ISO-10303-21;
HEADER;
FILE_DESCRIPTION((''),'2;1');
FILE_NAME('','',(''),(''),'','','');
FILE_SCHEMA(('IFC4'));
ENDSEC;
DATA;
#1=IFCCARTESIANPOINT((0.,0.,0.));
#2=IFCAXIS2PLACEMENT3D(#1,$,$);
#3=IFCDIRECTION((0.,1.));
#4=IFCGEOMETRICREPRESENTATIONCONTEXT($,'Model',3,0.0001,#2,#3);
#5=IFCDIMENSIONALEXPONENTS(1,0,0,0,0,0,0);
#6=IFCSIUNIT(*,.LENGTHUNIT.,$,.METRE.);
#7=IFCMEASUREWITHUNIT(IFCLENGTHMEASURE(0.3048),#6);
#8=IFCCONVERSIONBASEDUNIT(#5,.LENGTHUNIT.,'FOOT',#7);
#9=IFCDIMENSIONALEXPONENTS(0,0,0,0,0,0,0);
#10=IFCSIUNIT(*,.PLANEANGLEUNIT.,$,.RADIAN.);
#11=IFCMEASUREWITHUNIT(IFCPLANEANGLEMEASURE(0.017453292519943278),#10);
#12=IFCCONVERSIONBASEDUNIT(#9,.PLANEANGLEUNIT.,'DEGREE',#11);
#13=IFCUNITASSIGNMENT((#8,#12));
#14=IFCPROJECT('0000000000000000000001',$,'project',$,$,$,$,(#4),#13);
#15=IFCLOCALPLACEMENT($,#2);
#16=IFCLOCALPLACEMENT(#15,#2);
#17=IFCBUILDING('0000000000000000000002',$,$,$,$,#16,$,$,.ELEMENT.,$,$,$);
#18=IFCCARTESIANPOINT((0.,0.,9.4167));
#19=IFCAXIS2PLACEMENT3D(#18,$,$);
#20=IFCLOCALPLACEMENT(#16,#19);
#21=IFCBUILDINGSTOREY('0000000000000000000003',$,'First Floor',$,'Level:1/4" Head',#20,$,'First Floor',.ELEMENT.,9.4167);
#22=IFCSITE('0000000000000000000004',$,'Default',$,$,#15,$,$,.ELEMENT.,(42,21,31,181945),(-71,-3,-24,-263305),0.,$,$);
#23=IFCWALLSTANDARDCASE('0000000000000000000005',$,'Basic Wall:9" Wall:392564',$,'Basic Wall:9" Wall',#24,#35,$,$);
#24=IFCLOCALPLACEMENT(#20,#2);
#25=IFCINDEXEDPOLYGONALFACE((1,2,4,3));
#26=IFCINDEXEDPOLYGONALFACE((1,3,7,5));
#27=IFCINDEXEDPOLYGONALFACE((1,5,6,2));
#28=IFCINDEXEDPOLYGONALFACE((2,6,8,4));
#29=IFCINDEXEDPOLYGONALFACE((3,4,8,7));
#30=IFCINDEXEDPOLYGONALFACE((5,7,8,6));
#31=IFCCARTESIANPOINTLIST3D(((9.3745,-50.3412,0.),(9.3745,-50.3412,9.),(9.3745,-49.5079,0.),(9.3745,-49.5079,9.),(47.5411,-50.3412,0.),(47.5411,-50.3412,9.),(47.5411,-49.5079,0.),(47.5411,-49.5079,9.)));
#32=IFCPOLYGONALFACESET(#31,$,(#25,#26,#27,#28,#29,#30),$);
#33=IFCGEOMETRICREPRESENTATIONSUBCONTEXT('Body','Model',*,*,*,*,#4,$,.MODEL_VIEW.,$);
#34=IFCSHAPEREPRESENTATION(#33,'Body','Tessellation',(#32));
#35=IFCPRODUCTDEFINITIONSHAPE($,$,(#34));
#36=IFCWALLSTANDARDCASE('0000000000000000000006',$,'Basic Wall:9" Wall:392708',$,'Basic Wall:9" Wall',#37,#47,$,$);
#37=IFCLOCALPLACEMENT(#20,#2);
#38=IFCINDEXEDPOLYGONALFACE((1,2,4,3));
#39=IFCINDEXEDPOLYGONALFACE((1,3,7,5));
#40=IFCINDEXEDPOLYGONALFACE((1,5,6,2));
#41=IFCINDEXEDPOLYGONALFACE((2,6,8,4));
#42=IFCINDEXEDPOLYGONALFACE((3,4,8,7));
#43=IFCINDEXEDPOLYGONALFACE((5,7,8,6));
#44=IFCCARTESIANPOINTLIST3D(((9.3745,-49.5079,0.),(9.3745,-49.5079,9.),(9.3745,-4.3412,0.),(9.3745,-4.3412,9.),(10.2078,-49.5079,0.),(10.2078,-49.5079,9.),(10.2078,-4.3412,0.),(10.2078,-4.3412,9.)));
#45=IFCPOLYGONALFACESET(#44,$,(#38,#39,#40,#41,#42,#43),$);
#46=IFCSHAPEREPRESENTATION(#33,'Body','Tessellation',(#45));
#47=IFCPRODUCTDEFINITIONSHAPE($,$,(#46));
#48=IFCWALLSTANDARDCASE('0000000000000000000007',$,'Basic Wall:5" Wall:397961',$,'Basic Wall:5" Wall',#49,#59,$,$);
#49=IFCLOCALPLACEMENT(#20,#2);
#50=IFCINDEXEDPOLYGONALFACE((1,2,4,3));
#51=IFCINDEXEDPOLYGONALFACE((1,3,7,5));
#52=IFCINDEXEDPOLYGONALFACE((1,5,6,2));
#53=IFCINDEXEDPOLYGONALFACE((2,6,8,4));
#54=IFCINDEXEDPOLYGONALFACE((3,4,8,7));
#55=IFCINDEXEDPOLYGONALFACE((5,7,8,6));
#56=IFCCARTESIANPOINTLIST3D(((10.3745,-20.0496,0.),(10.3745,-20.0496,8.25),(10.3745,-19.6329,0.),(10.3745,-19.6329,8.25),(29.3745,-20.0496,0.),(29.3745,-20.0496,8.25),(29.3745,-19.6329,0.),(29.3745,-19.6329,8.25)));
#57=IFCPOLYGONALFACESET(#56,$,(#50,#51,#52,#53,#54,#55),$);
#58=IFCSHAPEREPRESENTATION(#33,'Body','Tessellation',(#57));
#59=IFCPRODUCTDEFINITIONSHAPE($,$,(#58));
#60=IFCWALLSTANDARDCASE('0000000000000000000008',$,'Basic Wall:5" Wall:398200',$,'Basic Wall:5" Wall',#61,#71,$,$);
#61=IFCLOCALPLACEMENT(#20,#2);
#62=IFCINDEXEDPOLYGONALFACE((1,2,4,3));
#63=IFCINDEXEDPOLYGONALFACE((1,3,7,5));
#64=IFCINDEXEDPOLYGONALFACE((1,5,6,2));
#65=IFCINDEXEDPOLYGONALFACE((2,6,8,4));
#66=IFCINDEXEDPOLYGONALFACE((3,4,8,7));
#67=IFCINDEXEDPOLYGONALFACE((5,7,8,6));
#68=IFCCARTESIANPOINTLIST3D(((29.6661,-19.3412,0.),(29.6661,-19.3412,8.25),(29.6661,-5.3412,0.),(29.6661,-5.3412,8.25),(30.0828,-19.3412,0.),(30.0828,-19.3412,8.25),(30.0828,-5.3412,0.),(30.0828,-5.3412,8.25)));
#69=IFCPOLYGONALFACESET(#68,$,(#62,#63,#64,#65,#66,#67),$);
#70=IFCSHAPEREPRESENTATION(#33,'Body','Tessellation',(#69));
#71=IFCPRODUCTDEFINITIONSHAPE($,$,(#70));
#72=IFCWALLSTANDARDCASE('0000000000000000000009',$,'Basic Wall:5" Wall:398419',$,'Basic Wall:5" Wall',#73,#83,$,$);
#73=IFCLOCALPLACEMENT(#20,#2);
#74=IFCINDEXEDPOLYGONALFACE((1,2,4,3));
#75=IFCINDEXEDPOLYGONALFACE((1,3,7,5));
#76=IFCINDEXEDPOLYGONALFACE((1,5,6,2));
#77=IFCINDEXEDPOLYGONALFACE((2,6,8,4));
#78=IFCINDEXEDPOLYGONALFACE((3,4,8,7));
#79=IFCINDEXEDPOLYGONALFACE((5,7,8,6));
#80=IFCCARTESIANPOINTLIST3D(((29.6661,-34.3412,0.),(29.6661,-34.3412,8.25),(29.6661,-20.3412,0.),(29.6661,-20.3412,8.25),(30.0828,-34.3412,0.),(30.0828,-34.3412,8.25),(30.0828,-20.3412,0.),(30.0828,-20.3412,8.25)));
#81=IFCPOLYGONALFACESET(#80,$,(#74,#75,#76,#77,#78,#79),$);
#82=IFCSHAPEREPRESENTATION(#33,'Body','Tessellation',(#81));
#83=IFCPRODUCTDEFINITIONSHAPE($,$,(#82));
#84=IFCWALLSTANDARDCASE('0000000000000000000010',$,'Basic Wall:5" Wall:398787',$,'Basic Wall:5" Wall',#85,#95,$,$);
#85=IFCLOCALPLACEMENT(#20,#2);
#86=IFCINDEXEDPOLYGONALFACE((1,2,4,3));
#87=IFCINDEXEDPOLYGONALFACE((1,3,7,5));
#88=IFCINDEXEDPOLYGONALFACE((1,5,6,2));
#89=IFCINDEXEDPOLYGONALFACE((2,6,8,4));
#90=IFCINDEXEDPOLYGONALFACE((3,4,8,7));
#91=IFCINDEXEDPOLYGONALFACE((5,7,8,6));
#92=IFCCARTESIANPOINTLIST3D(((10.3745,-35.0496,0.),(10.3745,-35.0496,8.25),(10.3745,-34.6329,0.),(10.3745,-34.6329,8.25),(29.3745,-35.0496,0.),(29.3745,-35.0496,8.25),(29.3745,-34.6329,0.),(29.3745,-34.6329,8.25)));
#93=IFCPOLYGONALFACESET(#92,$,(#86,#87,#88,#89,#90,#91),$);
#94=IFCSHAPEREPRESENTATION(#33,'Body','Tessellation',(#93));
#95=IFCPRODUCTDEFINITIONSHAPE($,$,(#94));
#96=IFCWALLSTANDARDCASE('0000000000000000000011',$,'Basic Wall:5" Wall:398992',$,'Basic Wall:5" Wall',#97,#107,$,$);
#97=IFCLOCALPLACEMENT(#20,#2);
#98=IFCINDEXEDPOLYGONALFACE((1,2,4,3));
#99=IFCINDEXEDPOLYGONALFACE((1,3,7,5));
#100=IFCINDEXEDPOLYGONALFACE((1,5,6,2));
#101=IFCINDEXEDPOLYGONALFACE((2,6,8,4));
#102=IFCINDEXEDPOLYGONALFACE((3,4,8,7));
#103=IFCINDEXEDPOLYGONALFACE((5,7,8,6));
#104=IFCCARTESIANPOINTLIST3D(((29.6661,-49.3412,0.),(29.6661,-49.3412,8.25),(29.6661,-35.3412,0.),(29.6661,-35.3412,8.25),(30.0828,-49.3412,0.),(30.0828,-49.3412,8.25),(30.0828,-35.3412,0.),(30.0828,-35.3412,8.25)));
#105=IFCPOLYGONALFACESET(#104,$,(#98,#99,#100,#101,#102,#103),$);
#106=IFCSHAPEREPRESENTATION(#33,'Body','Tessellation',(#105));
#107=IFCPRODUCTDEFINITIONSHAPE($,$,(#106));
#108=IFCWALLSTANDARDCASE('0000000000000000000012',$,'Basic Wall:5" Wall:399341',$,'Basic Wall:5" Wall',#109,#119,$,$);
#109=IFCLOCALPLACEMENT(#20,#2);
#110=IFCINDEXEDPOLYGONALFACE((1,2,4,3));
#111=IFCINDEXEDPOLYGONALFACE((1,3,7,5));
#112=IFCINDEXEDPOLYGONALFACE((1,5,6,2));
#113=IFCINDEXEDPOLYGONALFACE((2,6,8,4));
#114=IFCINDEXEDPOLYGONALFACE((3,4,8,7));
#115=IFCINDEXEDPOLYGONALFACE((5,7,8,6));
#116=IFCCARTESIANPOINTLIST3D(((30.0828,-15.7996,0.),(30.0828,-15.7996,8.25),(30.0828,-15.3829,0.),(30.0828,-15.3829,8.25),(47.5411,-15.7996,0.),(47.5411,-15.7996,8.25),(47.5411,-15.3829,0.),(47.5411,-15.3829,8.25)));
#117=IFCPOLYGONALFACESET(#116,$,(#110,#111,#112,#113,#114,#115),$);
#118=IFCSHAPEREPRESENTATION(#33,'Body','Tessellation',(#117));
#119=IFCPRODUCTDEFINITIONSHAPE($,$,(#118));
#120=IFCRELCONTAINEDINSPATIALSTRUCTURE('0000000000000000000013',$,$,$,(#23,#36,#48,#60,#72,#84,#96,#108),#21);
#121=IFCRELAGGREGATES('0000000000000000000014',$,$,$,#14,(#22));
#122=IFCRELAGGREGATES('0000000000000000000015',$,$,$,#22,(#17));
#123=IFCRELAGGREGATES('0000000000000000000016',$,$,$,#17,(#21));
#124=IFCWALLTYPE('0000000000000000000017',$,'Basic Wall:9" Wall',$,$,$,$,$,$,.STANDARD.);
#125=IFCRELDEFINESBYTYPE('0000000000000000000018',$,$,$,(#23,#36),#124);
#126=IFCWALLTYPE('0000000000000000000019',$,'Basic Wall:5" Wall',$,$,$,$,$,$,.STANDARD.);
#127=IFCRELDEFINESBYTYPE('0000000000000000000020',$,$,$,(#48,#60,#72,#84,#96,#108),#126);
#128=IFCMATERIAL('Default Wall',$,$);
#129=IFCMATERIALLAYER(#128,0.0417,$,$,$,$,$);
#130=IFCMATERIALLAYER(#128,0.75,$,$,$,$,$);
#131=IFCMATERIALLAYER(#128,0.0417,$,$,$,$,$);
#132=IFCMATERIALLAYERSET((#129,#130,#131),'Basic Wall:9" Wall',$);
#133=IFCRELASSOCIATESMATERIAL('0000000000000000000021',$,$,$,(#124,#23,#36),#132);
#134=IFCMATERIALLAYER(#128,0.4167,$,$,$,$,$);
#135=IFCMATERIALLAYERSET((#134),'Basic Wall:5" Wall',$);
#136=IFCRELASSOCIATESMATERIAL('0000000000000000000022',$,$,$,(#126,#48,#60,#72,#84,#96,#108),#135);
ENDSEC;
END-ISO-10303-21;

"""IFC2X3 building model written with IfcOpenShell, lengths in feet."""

from ifc_helpers import new_model, entity, si_unit, converted_unit, direction, frame, frame_2d, origin, place, context, subcontext, project, spatial, rectangle, extrude, material, layer, layer_set, layer_usage, type_object, element, save


model = new_model("IFC2X3")

# Units and contexts
model_context = context("Model", 3, precision=0.0001, world=origin(), true_north=direction((0.0, 1.0)))
body_context = subcontext(model_context, "Body", "Model", "MODEL_VIEW")
ifc_project = project(units=[converted_unit("LENGTHUNIT", "FOOT", entity("IfcLengthMeasure", 0.3048), si_unit("LENGTHUNIT", "METRE"), dimensions=[1, 0, 0, 0, 0, 0, 0]), converted_unit("PLANEANGLEUNIT", "DEGREE", entity("IfcPlaneAngleMeasure", 0.017453292519943278), si_unit("PLANEANGLEUNIT", "RADIAN"), dimensions=[0, 0, 0, 0, 0, 0, 0])], contexts=[model_context])

# Site, building, storey
site_placement = place(None, origin())
site = spatial("IfcSite", under=ifc_project, at=site_placement, Name="Default", CompositionType="ELEMENT", RefLatitude=(42, 21, 31, 181945), RefLongitude=(-71, -3, -24, -263305), RefElevation=0.0)
building_placement = place(site_placement, origin())
building = spatial("IfcBuilding", under=site, at=building_placement, CompositionType="ELEMENT")
storey_placement = place(building_placement, frame((0.0, 0.0, 9.4167)))
storey = spatial("IfcBuildingStorey", under=building, at=storey_placement, Name="First Floor", ObjectType="Level:1/4\" Head", LongName="First Floor", CompositionType="ELEMENT", Elevation=9.4167)

# Walls
ifc_material_1 = material(Name="Default Wall")
ifc_layer_1 = layer(ifc_material_1, 0.0417)
ifc_layer_2 = layer(ifc_material_1, 0.75)
ifc_layer_3 = layer(ifc_material_1, 0.0417)
ifc_layer_set_1 = layer_set([ifc_layer_1, ifc_layer_2, ifc_layer_3], Name="Basic Wall:9\" Wall")
ifc_layer_usage_1 = layer_usage(ifc_layer_set_1, "AXIS2", "NEGATIVE", 0.4167)
wall_type_1 = type_object("IfcWallType", Name="Basic Wall:9\" Wall", PredefinedType="STANDARD", material=ifc_layer_set_1)
wall_1_placement = place(storey_placement, frame((47.5411, -49.9246, 0.0), z_axis=(0.0, 0.0, 1.0), x_axis=(-1.0, 0.0, 0.0)))
element("IfcWallStandardCase", 1, at=wall_1_placement, inside=storey, type_object=wall_type_1, material=ifc_layer_usage_1, Name="Basic Wall:9\" Wall:392564", ObjectType="Basic Wall:9\" Wall", context=body_context, shape_type="SweptSolid", body=[
    extrude(rectangle(XDim=38.1667, YDim=0.8333, at=frame_2d((19.0833, 0.0), x_axis=(-1.0, 0.0))), origin(), (0.0, 0.0, 1.0), 9.0),
])
wall_2_placement = place(storey_placement, frame((9.7911, -49.5079, 0.0), z_axis=(0.0, 0.0, 1.0), x_axis=(0.0, 1.0, 0.0)))
element("IfcWallStandardCase", 2, at=wall_2_placement, inside=storey, type_object=wall_type_1, material=ifc_layer_usage_1, Name="Basic Wall:9\" Wall:392708", ObjectType="Basic Wall:9\" Wall", context=body_context, shape_type="SweptSolid", body=[
    extrude(rectangle(XDim=45.1667, YDim=0.8333, at=frame_2d((22.5833, 0.0), x_axis=(-1.0, 0.0))), origin(), (0.0, 0.0, 1.0), 9.0),
])
ifc_layer_4 = layer(ifc_material_1, 0.4167)
ifc_layer_set_2 = layer_set([ifc_layer_4], Name="Basic Wall:5\" Wall")
ifc_layer_usage_2 = layer_usage(ifc_layer_set_2, "AXIS2", "NEGATIVE", 0.2083)
wall_type_2 = type_object("IfcWallType", Name="Basic Wall:5\" Wall", PredefinedType="STANDARD", material=ifc_layer_set_2)
wall_3_placement = place(storey_placement, frame((10.3745, -19.8412, 0.0)))
element("IfcWallStandardCase", 3, at=wall_3_placement, inside=storey, type_object=wall_type_2, material=ifc_layer_usage_2, Name="Basic Wall:5\" Wall:397961", ObjectType="Basic Wall:5\" Wall", context=body_context, shape_type="SweptSolid", body=[
    extrude(rectangle(XDim=19.0, YDim=0.4167, at=frame_2d((9.5, 0.0), x_axis=(-1.0, 0.0))), origin(), (0.0, 0.0, 1.0), 8.25),
])
wall_4_placement = place(storey_placement, frame((29.8745, -19.3412, 0.0), z_axis=(0.0, 0.0, 1.0), x_axis=(0.0, 1.0, 0.0)))
element("IfcWallStandardCase", 4, at=wall_4_placement, inside=storey, type_object=wall_type_2, material=ifc_layer_usage_2, Name="Basic Wall:5\" Wall:398200", ObjectType="Basic Wall:5\" Wall", context=body_context, shape_type="SweptSolid", body=[
    extrude(rectangle(XDim=14.0, YDim=0.4167, at=frame_2d((7.0, 0.0), x_axis=(-1.0, 0.0))), origin(), (0.0, 0.0, 1.0), 8.25),
])
wall_5_placement = place(storey_placement, frame((29.8745, -20.3412, 0.0), z_axis=(0.0, 0.0, 1.0), x_axis=(0.0, -1.0, 0.0)))
element("IfcWallStandardCase", 5, at=wall_5_placement, inside=storey, type_object=wall_type_2, material=ifc_layer_usage_2, Name="Basic Wall:5\" Wall:398419", ObjectType="Basic Wall:5\" Wall", context=body_context, shape_type="SweptSolid", body=[
    extrude(rectangle(XDim=14.0, YDim=0.4167, at=frame_2d((7.0, 0.0), x_axis=(-1.0, 0.0))), origin(), (0.0, 0.0, 1.0), 8.25),
])
wall_6_placement = place(storey_placement, frame((29.3745, -34.8412, 0.0), z_axis=(0.0, 0.0, 1.0), x_axis=(-1.0, 0.0, 0.0)))
element("IfcWallStandardCase", 6, at=wall_6_placement, inside=storey, type_object=wall_type_2, material=ifc_layer_usage_2, Name="Basic Wall:5\" Wall:398787", ObjectType="Basic Wall:5\" Wall", context=body_context, shape_type="SweptSolid", body=[
    extrude(rectangle(XDim=19.0, YDim=0.4167, at=frame_2d((9.5, 0.0), x_axis=(-1.0, 0.0))), origin(), (0.0, 0.0, 1.0), 8.25),
])
wall_7_placement = place(storey_placement, frame((29.8745, -35.3412, 0.0), z_axis=(0.0, 0.0, 1.0), x_axis=(0.0, -1.0, 0.0)))
element("IfcWallStandardCase", 7, at=wall_7_placement, inside=storey, type_object=wall_type_2, material=ifc_layer_usage_2, Name="Basic Wall:5\" Wall:398992", ObjectType="Basic Wall:5\" Wall", context=body_context, shape_type="SweptSolid", body=[
    extrude(rectangle(XDim=14.0, YDim=0.4167, at=frame_2d((7.0, 0.0), x_axis=(-1.0, 0.0))), origin(), (0.0, 0.0, 1.0), 8.25),
])
wall_8_placement = place(storey_placement, frame((30.0828, -15.5912, 0.0)))
element("IfcWallStandardCase", 8, at=wall_8_placement, inside=storey, type_object=wall_type_2, material=ifc_layer_usage_2, Name="Basic Wall:5\" Wall:399341", ObjectType="Basic Wall:5\" Wall", context=body_context, shape_type="SweptSolid", body=[
    extrude(rectangle(XDim=17.4583, YDim=0.4167, at=frame_2d((8.7292, 0.0), x_axis=(-1.0, 0.0))), origin(), (0.0, 0.0, 1.0), 8.25),
])

save(model, "model.ifc")
